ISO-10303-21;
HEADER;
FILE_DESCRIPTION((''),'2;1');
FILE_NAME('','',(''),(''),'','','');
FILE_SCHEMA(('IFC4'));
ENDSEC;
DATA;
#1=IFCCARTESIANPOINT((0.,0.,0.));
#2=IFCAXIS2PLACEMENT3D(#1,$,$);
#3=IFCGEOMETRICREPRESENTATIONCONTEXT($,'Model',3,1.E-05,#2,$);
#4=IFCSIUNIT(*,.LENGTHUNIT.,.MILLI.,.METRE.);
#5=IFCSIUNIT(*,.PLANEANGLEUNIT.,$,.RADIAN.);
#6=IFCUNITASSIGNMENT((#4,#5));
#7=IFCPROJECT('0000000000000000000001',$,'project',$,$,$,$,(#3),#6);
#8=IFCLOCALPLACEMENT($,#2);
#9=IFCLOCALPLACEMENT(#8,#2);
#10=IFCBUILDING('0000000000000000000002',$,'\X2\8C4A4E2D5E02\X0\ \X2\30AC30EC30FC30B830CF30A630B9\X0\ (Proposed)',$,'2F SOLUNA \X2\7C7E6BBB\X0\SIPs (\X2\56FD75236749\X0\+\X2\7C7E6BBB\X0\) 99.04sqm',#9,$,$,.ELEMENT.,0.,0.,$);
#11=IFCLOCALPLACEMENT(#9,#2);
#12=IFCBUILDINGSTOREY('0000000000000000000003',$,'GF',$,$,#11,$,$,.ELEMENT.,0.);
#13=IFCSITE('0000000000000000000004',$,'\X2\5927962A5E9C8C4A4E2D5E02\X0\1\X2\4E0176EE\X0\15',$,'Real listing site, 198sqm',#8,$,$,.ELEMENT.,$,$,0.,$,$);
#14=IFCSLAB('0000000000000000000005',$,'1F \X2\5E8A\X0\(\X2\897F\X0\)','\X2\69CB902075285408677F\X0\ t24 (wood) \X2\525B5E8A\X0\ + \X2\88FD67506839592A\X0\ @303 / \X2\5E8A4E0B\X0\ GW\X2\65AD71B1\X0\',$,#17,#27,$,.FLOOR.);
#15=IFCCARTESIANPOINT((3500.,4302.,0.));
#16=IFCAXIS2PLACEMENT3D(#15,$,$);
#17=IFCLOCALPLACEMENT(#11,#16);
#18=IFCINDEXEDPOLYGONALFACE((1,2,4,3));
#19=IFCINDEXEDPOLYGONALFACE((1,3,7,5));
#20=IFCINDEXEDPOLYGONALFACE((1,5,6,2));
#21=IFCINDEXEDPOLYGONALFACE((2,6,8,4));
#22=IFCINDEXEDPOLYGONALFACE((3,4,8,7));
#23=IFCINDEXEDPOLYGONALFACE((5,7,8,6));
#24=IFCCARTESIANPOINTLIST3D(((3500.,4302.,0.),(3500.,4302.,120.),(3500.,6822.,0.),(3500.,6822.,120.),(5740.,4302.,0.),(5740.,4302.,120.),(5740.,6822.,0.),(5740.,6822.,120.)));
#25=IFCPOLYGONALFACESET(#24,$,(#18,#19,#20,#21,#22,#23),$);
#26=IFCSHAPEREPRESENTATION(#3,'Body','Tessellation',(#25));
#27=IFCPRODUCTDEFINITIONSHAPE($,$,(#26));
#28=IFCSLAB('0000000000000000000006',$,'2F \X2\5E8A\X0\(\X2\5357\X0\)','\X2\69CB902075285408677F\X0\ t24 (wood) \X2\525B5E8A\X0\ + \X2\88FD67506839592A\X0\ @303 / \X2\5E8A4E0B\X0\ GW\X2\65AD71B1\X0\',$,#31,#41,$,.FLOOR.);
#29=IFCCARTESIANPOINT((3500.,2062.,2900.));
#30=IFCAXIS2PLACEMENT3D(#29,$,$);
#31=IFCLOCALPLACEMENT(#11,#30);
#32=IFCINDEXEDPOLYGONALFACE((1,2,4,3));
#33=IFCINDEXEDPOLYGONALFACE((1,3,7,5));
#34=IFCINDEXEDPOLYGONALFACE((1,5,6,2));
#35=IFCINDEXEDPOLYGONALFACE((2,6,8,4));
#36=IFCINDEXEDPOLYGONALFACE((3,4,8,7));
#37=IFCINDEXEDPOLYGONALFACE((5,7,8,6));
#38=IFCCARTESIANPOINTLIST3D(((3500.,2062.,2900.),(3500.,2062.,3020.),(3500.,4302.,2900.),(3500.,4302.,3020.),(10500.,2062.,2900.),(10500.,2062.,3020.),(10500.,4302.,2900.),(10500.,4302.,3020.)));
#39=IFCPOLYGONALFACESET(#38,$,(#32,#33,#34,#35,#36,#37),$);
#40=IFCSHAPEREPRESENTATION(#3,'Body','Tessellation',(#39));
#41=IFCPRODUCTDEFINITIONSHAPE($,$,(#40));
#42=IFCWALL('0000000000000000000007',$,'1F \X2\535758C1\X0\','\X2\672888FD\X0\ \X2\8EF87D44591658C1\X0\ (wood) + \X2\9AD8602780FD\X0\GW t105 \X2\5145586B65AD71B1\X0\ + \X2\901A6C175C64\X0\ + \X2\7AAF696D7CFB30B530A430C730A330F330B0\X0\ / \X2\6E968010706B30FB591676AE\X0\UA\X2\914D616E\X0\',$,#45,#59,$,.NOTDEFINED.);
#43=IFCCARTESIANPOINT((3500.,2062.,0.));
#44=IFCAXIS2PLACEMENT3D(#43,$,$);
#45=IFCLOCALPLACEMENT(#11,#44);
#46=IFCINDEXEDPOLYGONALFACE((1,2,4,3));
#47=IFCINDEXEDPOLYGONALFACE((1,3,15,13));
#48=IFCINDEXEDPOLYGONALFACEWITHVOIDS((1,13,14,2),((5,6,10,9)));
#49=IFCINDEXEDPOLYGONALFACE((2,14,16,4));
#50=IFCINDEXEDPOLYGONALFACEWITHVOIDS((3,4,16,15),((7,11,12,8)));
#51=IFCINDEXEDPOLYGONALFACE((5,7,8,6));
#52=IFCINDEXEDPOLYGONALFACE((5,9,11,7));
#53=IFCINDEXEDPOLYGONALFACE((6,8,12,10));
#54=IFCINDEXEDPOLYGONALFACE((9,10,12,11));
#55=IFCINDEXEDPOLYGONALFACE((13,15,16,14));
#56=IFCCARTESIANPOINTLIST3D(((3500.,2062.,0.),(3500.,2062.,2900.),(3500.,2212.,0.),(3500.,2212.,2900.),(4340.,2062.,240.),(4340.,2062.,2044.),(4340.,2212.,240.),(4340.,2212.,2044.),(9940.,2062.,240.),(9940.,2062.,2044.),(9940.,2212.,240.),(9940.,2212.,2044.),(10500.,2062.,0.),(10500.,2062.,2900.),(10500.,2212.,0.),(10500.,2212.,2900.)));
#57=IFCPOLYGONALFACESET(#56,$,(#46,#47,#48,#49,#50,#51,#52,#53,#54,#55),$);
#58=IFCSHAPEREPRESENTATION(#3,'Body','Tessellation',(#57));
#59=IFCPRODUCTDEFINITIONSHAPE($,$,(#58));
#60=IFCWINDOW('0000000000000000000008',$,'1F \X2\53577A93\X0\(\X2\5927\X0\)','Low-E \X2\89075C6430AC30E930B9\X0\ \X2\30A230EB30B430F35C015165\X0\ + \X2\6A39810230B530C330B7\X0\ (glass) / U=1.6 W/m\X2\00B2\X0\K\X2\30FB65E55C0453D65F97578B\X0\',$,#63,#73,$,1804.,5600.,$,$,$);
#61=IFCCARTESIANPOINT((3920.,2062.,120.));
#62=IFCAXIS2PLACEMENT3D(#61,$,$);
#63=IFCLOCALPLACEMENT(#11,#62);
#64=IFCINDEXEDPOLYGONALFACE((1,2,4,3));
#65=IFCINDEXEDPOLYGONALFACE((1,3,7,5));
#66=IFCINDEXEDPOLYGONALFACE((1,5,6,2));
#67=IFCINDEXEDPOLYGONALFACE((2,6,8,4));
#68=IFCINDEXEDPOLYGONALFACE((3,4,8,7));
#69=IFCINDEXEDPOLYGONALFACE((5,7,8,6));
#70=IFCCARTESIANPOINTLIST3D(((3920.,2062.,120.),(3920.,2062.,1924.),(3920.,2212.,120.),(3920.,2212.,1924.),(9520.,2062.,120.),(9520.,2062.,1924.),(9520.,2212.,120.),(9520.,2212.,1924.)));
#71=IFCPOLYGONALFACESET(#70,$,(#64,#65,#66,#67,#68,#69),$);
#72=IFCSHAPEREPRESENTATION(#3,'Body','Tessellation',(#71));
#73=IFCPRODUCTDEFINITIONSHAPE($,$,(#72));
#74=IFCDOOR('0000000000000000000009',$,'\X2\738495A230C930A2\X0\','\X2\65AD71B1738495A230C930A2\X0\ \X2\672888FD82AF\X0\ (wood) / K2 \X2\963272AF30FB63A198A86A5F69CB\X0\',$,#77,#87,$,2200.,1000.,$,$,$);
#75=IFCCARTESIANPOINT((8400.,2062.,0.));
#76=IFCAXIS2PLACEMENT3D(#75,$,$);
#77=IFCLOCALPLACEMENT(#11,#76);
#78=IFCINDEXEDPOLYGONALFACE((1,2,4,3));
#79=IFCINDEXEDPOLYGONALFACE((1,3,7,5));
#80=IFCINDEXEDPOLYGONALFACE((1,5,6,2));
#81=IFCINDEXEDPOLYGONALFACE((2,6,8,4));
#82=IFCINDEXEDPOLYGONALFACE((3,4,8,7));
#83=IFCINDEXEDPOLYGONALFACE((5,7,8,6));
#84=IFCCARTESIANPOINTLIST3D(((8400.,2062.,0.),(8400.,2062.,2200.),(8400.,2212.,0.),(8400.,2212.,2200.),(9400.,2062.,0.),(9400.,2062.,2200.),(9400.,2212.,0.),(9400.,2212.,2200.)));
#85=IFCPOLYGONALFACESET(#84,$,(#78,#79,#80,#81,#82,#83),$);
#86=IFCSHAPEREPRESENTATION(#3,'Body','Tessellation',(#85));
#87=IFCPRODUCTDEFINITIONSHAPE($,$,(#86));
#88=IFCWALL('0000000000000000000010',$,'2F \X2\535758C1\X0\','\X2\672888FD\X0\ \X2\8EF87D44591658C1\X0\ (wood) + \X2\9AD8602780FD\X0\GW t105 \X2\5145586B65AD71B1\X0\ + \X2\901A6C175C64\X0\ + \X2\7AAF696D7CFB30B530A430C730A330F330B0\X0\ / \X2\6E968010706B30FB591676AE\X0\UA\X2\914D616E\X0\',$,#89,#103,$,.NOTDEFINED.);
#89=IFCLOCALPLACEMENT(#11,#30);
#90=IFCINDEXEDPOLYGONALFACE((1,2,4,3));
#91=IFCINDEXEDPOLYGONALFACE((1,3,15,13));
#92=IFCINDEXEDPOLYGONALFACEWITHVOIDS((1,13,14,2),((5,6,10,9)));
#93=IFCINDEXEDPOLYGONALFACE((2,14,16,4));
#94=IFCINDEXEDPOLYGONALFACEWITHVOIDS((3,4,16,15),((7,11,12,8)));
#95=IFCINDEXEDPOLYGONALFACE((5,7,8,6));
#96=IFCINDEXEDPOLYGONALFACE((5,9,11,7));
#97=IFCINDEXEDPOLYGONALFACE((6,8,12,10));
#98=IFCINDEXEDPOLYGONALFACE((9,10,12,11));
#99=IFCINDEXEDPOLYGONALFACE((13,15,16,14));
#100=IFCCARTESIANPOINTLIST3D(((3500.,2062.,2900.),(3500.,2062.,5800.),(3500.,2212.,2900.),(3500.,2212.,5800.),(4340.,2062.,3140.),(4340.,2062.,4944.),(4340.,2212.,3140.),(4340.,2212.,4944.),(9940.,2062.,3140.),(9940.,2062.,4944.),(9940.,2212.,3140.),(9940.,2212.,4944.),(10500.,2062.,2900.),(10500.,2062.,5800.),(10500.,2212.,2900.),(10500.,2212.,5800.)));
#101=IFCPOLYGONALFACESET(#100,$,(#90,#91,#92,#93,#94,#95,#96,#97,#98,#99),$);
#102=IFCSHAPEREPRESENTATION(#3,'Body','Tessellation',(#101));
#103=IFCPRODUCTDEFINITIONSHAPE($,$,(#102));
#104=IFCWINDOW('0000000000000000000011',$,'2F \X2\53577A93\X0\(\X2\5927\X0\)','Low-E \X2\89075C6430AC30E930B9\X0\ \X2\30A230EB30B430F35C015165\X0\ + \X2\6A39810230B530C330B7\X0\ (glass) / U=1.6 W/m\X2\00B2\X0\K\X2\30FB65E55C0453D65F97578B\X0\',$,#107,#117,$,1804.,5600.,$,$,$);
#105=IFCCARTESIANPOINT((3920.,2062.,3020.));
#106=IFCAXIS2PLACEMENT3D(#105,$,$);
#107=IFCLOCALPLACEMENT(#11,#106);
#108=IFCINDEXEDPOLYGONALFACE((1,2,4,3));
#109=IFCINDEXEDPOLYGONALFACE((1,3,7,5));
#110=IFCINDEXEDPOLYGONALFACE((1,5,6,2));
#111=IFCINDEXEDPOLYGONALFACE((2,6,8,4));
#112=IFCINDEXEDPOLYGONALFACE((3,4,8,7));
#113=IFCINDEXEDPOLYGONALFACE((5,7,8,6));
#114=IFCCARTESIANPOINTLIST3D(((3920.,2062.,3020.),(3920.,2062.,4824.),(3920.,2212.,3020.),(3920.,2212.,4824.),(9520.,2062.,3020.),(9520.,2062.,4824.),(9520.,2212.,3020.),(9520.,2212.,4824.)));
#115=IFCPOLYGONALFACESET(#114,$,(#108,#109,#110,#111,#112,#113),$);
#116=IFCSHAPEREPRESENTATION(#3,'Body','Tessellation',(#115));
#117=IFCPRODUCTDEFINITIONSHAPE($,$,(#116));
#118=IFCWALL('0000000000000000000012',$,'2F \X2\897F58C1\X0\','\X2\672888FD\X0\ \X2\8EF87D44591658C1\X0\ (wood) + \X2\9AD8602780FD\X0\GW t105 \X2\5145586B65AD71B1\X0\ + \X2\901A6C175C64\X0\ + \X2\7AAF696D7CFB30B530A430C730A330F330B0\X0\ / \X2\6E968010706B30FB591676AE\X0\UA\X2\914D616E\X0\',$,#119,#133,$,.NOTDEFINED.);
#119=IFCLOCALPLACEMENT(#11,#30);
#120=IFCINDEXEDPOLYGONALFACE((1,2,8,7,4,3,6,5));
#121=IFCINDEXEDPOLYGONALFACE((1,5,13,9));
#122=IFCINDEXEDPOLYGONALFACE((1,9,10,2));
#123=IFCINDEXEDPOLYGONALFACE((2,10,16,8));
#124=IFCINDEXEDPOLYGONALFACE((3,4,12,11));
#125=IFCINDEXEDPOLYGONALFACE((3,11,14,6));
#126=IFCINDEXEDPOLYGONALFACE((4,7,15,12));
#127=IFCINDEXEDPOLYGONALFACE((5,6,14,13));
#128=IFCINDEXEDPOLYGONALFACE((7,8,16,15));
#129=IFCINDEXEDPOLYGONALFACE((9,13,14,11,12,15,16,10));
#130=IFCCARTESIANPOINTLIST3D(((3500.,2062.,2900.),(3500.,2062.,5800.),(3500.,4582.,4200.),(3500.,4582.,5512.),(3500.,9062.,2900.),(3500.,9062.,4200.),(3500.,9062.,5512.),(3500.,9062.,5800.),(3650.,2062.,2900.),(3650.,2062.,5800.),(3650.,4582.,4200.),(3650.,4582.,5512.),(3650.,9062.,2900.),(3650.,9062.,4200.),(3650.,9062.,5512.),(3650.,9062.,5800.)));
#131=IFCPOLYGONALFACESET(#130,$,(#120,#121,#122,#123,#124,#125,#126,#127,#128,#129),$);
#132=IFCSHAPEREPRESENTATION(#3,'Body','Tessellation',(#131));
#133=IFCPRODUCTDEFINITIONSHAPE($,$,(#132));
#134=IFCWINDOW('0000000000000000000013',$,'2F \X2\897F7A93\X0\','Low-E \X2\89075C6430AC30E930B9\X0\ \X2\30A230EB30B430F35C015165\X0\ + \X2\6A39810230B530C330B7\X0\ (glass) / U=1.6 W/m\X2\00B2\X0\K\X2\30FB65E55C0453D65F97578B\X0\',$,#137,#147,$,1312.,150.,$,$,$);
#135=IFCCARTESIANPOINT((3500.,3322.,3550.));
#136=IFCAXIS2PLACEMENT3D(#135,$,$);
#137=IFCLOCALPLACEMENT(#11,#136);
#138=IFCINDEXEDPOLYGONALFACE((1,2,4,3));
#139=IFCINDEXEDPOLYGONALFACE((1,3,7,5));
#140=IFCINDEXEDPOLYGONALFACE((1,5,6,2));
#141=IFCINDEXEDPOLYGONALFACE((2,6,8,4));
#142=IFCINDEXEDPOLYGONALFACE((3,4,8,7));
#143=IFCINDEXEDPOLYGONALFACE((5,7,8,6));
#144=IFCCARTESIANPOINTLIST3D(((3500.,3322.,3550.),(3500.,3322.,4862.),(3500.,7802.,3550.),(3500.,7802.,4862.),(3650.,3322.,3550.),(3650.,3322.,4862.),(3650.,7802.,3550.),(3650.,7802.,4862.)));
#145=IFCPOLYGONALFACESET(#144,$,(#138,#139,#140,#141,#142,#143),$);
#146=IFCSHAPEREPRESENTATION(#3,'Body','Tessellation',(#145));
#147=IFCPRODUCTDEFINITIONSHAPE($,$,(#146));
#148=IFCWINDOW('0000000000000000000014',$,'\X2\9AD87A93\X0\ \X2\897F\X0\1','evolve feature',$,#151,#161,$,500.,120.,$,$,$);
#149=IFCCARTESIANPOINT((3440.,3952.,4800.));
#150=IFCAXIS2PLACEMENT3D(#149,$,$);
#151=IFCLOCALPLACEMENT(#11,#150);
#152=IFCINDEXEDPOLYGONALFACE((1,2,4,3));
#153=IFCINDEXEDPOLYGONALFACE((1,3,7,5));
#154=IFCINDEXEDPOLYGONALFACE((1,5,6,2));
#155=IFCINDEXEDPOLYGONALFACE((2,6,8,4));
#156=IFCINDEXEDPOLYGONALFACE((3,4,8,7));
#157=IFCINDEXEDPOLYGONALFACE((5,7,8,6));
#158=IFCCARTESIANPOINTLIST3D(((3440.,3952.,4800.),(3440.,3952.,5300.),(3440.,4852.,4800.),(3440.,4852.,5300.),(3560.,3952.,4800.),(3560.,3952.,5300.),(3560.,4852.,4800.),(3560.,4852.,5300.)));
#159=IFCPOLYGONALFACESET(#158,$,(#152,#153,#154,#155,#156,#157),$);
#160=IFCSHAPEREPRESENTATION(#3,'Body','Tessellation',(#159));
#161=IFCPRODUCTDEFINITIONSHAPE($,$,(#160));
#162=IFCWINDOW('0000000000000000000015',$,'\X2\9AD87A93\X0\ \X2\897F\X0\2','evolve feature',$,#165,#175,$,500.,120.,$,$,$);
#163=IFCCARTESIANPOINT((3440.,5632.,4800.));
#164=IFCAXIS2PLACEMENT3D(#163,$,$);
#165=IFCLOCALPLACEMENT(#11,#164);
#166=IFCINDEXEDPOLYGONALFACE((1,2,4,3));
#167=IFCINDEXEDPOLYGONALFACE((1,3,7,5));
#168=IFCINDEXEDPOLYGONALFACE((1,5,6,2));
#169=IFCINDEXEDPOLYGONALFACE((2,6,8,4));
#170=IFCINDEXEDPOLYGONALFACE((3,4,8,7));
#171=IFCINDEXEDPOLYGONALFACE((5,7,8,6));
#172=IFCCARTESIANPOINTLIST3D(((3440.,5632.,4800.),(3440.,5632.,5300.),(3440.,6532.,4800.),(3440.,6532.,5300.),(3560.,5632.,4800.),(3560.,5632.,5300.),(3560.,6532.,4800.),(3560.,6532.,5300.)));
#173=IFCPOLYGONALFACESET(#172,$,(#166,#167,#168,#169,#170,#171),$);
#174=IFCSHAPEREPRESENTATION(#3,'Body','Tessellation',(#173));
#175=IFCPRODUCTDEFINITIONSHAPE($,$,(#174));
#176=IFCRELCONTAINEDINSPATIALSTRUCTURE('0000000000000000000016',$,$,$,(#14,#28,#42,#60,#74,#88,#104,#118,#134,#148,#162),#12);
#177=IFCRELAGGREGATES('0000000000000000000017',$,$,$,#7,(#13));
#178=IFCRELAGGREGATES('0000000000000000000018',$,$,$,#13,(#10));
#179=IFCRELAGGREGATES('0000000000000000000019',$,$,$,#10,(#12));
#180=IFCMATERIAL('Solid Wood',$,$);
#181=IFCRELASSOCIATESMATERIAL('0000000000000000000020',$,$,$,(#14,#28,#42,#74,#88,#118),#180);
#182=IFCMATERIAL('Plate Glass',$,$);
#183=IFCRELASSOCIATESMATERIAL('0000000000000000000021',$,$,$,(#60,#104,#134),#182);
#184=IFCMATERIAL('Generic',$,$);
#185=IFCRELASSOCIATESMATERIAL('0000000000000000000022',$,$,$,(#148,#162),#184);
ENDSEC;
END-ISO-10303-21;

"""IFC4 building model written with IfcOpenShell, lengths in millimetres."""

from ifc_helpers import new_model, si_unit, frame, frame_2d, origin, place, context, project, spatial, rectangle, extrude, material, element, fill, save


model = new_model("IFC4")

# Units and contexts
model_context = context("Model", 3, precision=1e-05, world=origin())
ifc_project = project(units=[si_unit("LENGTHUNIT", "METRE", prefix="MILLI"), si_unit("PLANEANGLEUNIT", "RADIAN")], contexts=[model_context])

# Site, building, storey
site_placement = place(None, origin())
site = spatial("IfcSite", under=ifc_project, at=site_placement, Name="大阪府豊中市1丁目15", ObjectType="Real listing site, 198sqm", CompositionType="ELEMENT", RefElevation=0.0)
building_placement = place(site_placement, origin())
building = spatial("IfcBuilding", under=site, at=building_placement, Name="豊中市 ガレージハウス (Proposed)", ObjectType="2F SOLUNA 籾殻SIPs (国産杉+籾殻) 99.04sqm", CompositionType="ELEMENT", ElevationOfRefHeight=0.0, ElevationOfTerrain=0.0)
storey_placement = place(building_placement, origin())
storey = spatial("IfcBuildingStorey", under=building, at=storey_placement, Name="GF", CompositionType="ELEMENT", Elevation=0.0)

# Slabs
ifc_material_1 = material(Name="Solid Wood")
slab_1_placement = place(storey_placement, frame((3500.0, 4302.0, 0.0)))
element("IfcSlab", 1, at=slab_1_placement, inside=storey, material=ifc_material_1, Name="1F 床(西)", Description="構造用合板 t24 (wood) 剛床 + 製材根太 @303 / 床下 GW断熱", PredefinedType="FLOOR", context=model_context, shape_type="SweptSolid", body=[
    extrude(rectangle(XDim=2240.0, YDim=2520.0, at=frame_2d((1120.0, 1260.0))), frame((3500.0, 4302.0, 0.0)), (0.0, 0.0, 1.0), 120.0),
])
slab_2_placement = place(storey_placement, frame((3500.0, 2062.0, 2900.0)))
element("IfcSlab", 2, at=slab_2_placement, inside=storey, material=ifc_material_1, Name="2F 床(南)", Description="構造用合板 t24 (wood) 剛床 + 製材根太 @303 / 床下 GW断熱", PredefinedType="FLOOR", context=model_context, shape_type="SweptSolid", body=[
    extrude(rectangle(XDim=7000.0, YDim=2240.0, at=frame_2d((3500.0, 1120.0))), frame((3500.0, 2062.0, 2900.0)), (0.0, 0.0, 1.0), 120.0),
])
ifc_material_2 = material(Name="Generic")

# Wall, openings, window, door
wall_1_placement = place(storey_placement, frame((3500.0, 2062.0, 0.0)))
wall_1 = element("IfcWall", 3, at=wall_1_placement, inside=storey, material=ifc_material_1, Name="1F 南壁", Description="木製 軸組外壁 (wood) + 高性能GW t105 充填断熱 + 通気層 + 窯業系サイディング / 準耐火・外皮UA配慮", PredefinedType="NOTDEFINED", context=model_context, shape_type="SweptSolid", body=[
    extrude(rectangle(XDim=7000.0, YDim=150.0, at=frame_2d((3500.0, 75.0))), frame((3500.0, 2062.0, 0.0)), (0.0, 0.0, 1.0), 2900.0),
])
opening_1_placement = place(storey_placement, frame((3920.0, 2062.0, 120.0)))
opening_1 = element("IfcOpeningElement", 4, at=opening_1_placement, cuts=wall_1, PredefinedType="NOTDEFINED", context=model_context, shape_type="SweptSolid", body=[
    extrude(rectangle(XDim=5600.0, YDim=150.0, at=frame_2d((2800.0, 75.0))), frame((3920.0, 2062.0, 120.0)), (0.0, 0.0, 1.0), 1804.0),
])
opening_2_placement = place(storey_placement, frame((8400.0, 2062.0, 0.0)))
opening_2 = element("IfcOpeningElement", 5, at=opening_2_placement, cuts=wall_1, PredefinedType="NOTDEFINED", context=model_context, shape_type="SweptSolid", body=[
    extrude(rectangle(XDim=1000.0, YDim=150.0, at=frame_2d((500.0, 75.0))), frame((8400.0, 2062.0, 0.0)), (0.0, 0.0, 1.0), 2200.0),
])
ifc_material_3 = material(Name="Plate Glass")
window_1_placement = place(storey_placement, frame((3920.0, 2062.0, 120.0)))
window_1 = element("IfcWindow", 6, at=window_1_placement, inside=storey, material=ifc_material_3, Name="1F 南窓(大)", Description="Low-E 複層ガラス アルゴン封入 + 樹脂サッシ (glass) / U=1.6 W/m²K・日射取得型", OverallHeight=1804.0, OverallWidth=5600.0, context=model_context, shape_type="SweptSolid", body=[
    extrude(rectangle(XDim=5600.0, YDim=150.0, at=frame_2d((2800.0, 75.0))), frame((3920.0, 2062.0, 120.0)), (0.0, 0.0, 1.0), 1804.0),
])
fill(opening_1, window_1)
door_placement = place(storey_placement, frame((8400.0, 2062.0, 0.0)))
door = element("IfcDoor", 7, at=door_placement, inside=storey, material=ifc_material_1, Name="玄関ドア", Description="断熱玄関ドア 木製芯 (wood) / K2 防犯・採風機構", OverallHeight=2200.0, OverallWidth=1000.0, context=model_context, shape_type="SweptSolid", body=[
    extrude(rectangle(XDim=1000.0, YDim=150.0, at=frame_2d((500.0, 75.0))), frame((8400.0, 2062.0, 0.0)), (0.0, 0.0, 1.0), 2200.0),
])
fill(opening_2, door)

# Wall, opening, window
wall_2_placement = place(storey_placement, frame((3500.0, 2062.0, 2900.0)))
wall_2 = element("IfcWall", 8, at=wall_2_placement, inside=storey, material=ifc_material_1, Name="2F 南壁", Description="木製 軸組外壁 (wood) + 高性能GW t105 充填断熱 + 通気層 + 窯業系サイディング / 準耐火・外皮UA配慮", PredefinedType="NOTDEFINED", context=model_context, shape_type="SweptSolid", body=[
    extrude(rectangle(XDim=7000.0, YDim=150.0, at=frame_2d((3500.0, 75.0))), frame((3500.0, 2062.0, 2900.0)), (0.0, 0.0, 1.0), 2900.0),
])
opening_3_placement = place(storey_placement, frame((3920.0, 2062.0, 3020.0)))
opening_3 = element("IfcOpeningElement", 9, at=opening_3_placement, cuts=wall_2, PredefinedType="NOTDEFINED", context=model_context, shape_type="SweptSolid", body=[
    extrude(rectangle(XDim=5600.0, YDim=150.0, at=frame_2d((2800.0, 75.0))), frame((3920.0, 2062.0, 3020.0)), (0.0, 0.0, 1.0), 1804.0),
])
window_2_placement = place(storey_placement, frame((3920.0, 2062.0, 3020.0)))
window_2 = element("IfcWindow", 10, at=window_2_placement, inside=storey, material=ifc_material_3, Name="2F 南窓(大)", Description="Low-E 複層ガラス アルゴン封入 + 樹脂サッシ (glass) / U=1.6 W/m²K・日射取得型", OverallHeight=1804.0, OverallWidth=5600.0, context=model_context, shape_type="SweptSolid", body=[
    extrude(rectangle(XDim=5600.0, YDim=150.0, at=frame_2d((2800.0, 75.0))), frame((3920.0, 2062.0, 3020.0)), (0.0, 0.0, 1.0), 1804.0),
])
fill(opening_3, window_2)

# Wall, openings, windows
wall_3_placement = place(storey_placement, frame((3500.0, 2062.0, 2900.0)))
wall_3 = element("IfcWall", 11, at=wall_3_placement, inside=storey, material=ifc_material_1, Name="2F 西壁", Description="木製 軸組外壁 (wood) + 高性能GW t105 充填断熱 + 通気層 + 窯業系サイディング / 準耐火・外皮UA配慮", PredefinedType="NOTDEFINED", context=model_context, shape_type="SweptSolid", body=[
    extrude(rectangle(XDim=150.0, YDim=7000.0, at=frame_2d((75.0, 3500.0))), frame((3500.0, 2062.0, 2900.0)), (0.0, 0.0, 1.0), 2900.0),
])
opening_4_placement = place(storey_placement, frame((3500.0, 3322.0, 3550.0)))
opening_4 = element("IfcOpeningElement", 12, at=opening_4_placement, cuts=wall_3, PredefinedType="NOTDEFINED", context=model_context, shape_type="SweptSolid", body=[
    extrude(rectangle(XDim=150.0, YDim=4480.0, at=frame_2d((75.0, 2240.0))), frame((3500.0, 3322.0, 3550.0)), (0.0, 0.0, 1.0), 1312.0),
])
opening_5_placement = place(storey_placement, frame((3440.0, 3952.0, 4800.0)))
opening_5 = element("IfcOpeningElement", 13, at=opening_5_placement, cuts=wall_3, PredefinedType="NOTDEFINED", context=model_context, shape_type="SweptSolid", body=[
    extrude(rectangle(XDim=120.0, YDim=900.0, at=frame_2d((60.0, 450.0))), frame((3440.0, 3952.0, 4800.0)), (0.0, 0.0, 1.0), 500.0),
])
opening_6_placement = place(storey_placement, frame((3440.0, 5632.0, 4800.0)))
opening_6 = element("IfcOpeningElement", 14, at=opening_6_placement, cuts=wall_3, PredefinedType="NOTDEFINED", context=model_context, shape_type="SweptSolid", body=[
    extrude(rectangle(XDim=120.0, YDim=900.0, at=frame_2d((60.0, 450.0))), frame((3440.0, 5632.0, 4800.0)), (0.0, 0.0, 1.0), 500.0),
])
window_3_placement = place(storey_placement, frame((3500.0, 3322.0, 3550.0)))
window_3 = element("IfcWindow", 15, at=window_3_placement, inside=storey, material=ifc_material_3, Name="2F 西窓", Description="Low-E 複層ガラス アルゴン封入 + 樹脂サッシ (glass) / U=1.6 W/m²K・日射取得型", OverallHeight=1312.0, OverallWidth=150.0, context=model_context, shape_type="SweptSolid", body=[
    extrude(rectangle(XDim=150.0, YDim=4480.0, at=frame_2d((75.0, 2240.0))), frame((3500.0, 3322.0, 3550.0)), (0.0, 0.0, 1.0), 1312.0),
])
fill(opening_4, window_3)
window_4_placement = place(storey_placement, frame((3440.0, 3952.0, 4800.0)))
window_4 = element("IfcWindow", 16, at=window_4_placement, inside=storey, material=ifc_material_2, Name="高窓 西1", Description="evolve feature", OverallHeight=500.0, OverallWidth=120.0, context=model_context, shape_type="SweptSolid", body=[
    extrude(rectangle(XDim=120.0, YDim=900.0, at=frame_2d((60.0, 450.0))), frame((3440.0, 3952.0, 4800.0)), (0.0, 0.0, 1.0), 500.0),
])
fill(opening_5, window_4)
window_5_placement = place(storey_placement, frame((3440.0, 5632.0, 4800.0)))
window_5 = element("IfcWindow", 17, at=window_5_placement, inside=storey, material=ifc_material_2, Name="高窓 西2", Description="evolve feature", OverallHeight=500.0, OverallWidth=120.0, context=model_context, shape_type="SweptSolid", body=[
    extrude(rectangle(XDim=120.0, YDim=900.0, at=frame_2d((60.0, 450.0))), frame((3440.0, 5632.0, 4800.0)), (0.0, 0.0, 1.0), 500.0),
])
fill(opening_6, window_5)

save(model, "model.ifc")
